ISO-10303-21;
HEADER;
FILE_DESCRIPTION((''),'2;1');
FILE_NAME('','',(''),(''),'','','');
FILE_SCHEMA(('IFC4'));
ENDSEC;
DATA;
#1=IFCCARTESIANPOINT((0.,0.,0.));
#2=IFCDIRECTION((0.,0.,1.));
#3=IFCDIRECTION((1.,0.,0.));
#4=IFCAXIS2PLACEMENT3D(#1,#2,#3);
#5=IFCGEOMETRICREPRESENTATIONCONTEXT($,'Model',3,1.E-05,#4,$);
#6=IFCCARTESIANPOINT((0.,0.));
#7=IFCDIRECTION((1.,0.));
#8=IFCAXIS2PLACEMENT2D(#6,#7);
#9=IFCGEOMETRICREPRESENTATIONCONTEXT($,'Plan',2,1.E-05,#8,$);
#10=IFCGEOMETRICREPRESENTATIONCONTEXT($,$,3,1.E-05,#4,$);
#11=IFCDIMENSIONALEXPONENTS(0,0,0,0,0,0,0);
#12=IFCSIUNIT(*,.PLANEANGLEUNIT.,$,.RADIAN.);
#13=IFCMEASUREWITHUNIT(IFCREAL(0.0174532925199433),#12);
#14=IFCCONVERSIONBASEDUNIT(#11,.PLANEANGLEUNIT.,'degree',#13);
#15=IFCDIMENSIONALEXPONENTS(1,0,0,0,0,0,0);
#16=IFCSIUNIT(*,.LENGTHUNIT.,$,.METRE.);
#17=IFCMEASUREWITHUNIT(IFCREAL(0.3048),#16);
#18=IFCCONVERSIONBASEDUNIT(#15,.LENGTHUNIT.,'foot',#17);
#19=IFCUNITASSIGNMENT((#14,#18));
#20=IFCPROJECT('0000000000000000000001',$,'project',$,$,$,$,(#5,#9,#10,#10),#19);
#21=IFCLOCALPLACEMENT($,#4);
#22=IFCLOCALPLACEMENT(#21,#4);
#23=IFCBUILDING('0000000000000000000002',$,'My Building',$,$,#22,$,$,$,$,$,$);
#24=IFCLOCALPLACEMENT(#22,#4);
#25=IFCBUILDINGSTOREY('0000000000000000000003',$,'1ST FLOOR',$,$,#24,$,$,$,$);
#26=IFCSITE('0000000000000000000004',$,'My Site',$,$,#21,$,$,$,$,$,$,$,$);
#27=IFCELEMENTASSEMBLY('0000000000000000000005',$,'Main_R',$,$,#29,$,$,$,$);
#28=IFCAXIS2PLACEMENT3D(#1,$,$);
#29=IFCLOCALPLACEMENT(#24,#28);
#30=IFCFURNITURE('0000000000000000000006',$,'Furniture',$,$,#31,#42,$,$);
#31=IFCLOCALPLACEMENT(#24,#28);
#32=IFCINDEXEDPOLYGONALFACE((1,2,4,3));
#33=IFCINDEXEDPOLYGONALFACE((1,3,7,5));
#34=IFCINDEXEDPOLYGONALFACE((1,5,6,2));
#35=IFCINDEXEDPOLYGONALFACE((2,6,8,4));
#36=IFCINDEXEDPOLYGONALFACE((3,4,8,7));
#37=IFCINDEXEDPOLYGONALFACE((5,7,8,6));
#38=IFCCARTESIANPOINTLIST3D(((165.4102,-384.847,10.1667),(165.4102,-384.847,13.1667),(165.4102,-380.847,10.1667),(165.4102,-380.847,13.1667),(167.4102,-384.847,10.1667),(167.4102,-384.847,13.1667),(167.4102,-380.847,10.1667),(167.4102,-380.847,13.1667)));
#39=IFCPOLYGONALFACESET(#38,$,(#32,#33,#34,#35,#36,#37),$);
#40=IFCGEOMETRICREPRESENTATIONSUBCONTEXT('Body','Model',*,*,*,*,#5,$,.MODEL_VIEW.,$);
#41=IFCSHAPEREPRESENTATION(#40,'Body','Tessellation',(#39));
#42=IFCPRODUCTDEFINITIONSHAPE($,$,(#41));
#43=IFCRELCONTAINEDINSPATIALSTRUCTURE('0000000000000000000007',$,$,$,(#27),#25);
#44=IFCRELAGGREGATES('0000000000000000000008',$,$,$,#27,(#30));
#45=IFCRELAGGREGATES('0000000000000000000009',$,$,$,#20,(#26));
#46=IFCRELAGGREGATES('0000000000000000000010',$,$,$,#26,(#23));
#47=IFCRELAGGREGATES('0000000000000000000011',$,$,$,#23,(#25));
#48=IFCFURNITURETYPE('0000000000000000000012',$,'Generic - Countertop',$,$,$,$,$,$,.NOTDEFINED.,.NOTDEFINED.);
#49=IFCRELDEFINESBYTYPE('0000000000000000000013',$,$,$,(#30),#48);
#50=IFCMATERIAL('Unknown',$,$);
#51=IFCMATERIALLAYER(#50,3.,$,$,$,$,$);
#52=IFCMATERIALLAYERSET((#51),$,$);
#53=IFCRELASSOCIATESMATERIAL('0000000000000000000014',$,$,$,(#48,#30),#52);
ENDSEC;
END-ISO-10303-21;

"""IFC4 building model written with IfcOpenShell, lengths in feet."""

from ifc_helpers import new_model, entity, si_unit, converted_unit, frame, origin_with_axes, origin_2d_with_axis, place, context, subcontext, project, spatial, line, indexed_curve, outline, extrude, material, layer, layer_set, layer_usage, type_object, element, aggregate, save


model = new_model("IFC4")

# Units and contexts
model_context = context("Model", 3, precision=1e-05, world=origin_with_axes())
plan_context = context("Plan", 2, precision=1e-05, world=origin_2d_with_axis())
context_of_model = context(None, 3, precision=1e-05, world=origin_with_axes())
body_context = subcontext(model_context, "Body", "Model", "MODEL_VIEW")
ifc_project = project(units=[converted_unit("PLANEANGLEUNIT", "degree", entity("IfcReal", 0.0174532925199433), si_unit("PLANEANGLEUNIT", "RADIAN"), dimensions=[0, 0, 0, 0, 0, 0, 0]), converted_unit("LENGTHUNIT", "foot", entity("IfcReal", 0.3048), si_unit("LENGTHUNIT", "METRE"), dimensions=[1, 0, 0, 0, 0, 0, 0])], contexts=[model_context, plan_context, context_of_model, context_of_model])

# Site, building, storey
site_placement = place(None, origin_with_axes())
site = spatial("IfcSite", under=ifc_project, at=site_placement, Name="My Site")
building_placement = place(site_placement, origin_with_axes())
building = spatial("IfcBuilding", under=site, at=building_placement, Name="My Building")
storey_placement = place(building_placement, origin_with_axes())
storey = spatial("IfcBuildingStorey", under=building, at=storey_placement, Name="1ST FLOOR")

# Element assembly
assembly_1_placement = place(storey_placement, origin_with_axes())
assembly_1 = element("IfcElementAssembly", 1, at=assembly_1_placement, inside=storey, Name="Main_R")
ifc_material_1 = material(Name="Unknown")

# Furniture
ifc_layer_1 = layer(ifc_material_1, 3.0)
ifc_layer_set_1 = layer_set([ifc_layer_1])
ifc_layer_usage_1 = layer_usage(ifc_layer_set_1, "AXIS3", "POSITIVE", 0.0)
furniture_type = type_object("IfcFurnitureType", Name="Generic - Countertop", AssemblyPlace="NOTDEFINED", PredefinedType="NOTDEFINED", material=ifc_layer_set_1)
furniture_placement = place(assembly_1_placement, frame((165.4102, -384.847, 10.1667), z_axis=(0.0, 0.0, 1.0), x_axis=(1.0, 0.0, 0.0)))
furniture = element("IfcFurniture", 2, at=furniture_placement, type_object=furniture_type, material=ifc_layer_usage_1, Name="Furniture", context=body_context, shape_type="SweptSolid", body=[
    extrude(outline(indexed_curve([(2.0, 4.0), (0.0, 4.0), (0.0, 0.0), (2.0, 0.0)], segments=[line(4, 1), line(1, 2), line(2, 3), line(3, 4)], self_intersect=False)), None, (0.0, 0.0, 1.0), 3.0),
])
aggregate(assembly_1, [furniture])

save(model, "model.ifc")
